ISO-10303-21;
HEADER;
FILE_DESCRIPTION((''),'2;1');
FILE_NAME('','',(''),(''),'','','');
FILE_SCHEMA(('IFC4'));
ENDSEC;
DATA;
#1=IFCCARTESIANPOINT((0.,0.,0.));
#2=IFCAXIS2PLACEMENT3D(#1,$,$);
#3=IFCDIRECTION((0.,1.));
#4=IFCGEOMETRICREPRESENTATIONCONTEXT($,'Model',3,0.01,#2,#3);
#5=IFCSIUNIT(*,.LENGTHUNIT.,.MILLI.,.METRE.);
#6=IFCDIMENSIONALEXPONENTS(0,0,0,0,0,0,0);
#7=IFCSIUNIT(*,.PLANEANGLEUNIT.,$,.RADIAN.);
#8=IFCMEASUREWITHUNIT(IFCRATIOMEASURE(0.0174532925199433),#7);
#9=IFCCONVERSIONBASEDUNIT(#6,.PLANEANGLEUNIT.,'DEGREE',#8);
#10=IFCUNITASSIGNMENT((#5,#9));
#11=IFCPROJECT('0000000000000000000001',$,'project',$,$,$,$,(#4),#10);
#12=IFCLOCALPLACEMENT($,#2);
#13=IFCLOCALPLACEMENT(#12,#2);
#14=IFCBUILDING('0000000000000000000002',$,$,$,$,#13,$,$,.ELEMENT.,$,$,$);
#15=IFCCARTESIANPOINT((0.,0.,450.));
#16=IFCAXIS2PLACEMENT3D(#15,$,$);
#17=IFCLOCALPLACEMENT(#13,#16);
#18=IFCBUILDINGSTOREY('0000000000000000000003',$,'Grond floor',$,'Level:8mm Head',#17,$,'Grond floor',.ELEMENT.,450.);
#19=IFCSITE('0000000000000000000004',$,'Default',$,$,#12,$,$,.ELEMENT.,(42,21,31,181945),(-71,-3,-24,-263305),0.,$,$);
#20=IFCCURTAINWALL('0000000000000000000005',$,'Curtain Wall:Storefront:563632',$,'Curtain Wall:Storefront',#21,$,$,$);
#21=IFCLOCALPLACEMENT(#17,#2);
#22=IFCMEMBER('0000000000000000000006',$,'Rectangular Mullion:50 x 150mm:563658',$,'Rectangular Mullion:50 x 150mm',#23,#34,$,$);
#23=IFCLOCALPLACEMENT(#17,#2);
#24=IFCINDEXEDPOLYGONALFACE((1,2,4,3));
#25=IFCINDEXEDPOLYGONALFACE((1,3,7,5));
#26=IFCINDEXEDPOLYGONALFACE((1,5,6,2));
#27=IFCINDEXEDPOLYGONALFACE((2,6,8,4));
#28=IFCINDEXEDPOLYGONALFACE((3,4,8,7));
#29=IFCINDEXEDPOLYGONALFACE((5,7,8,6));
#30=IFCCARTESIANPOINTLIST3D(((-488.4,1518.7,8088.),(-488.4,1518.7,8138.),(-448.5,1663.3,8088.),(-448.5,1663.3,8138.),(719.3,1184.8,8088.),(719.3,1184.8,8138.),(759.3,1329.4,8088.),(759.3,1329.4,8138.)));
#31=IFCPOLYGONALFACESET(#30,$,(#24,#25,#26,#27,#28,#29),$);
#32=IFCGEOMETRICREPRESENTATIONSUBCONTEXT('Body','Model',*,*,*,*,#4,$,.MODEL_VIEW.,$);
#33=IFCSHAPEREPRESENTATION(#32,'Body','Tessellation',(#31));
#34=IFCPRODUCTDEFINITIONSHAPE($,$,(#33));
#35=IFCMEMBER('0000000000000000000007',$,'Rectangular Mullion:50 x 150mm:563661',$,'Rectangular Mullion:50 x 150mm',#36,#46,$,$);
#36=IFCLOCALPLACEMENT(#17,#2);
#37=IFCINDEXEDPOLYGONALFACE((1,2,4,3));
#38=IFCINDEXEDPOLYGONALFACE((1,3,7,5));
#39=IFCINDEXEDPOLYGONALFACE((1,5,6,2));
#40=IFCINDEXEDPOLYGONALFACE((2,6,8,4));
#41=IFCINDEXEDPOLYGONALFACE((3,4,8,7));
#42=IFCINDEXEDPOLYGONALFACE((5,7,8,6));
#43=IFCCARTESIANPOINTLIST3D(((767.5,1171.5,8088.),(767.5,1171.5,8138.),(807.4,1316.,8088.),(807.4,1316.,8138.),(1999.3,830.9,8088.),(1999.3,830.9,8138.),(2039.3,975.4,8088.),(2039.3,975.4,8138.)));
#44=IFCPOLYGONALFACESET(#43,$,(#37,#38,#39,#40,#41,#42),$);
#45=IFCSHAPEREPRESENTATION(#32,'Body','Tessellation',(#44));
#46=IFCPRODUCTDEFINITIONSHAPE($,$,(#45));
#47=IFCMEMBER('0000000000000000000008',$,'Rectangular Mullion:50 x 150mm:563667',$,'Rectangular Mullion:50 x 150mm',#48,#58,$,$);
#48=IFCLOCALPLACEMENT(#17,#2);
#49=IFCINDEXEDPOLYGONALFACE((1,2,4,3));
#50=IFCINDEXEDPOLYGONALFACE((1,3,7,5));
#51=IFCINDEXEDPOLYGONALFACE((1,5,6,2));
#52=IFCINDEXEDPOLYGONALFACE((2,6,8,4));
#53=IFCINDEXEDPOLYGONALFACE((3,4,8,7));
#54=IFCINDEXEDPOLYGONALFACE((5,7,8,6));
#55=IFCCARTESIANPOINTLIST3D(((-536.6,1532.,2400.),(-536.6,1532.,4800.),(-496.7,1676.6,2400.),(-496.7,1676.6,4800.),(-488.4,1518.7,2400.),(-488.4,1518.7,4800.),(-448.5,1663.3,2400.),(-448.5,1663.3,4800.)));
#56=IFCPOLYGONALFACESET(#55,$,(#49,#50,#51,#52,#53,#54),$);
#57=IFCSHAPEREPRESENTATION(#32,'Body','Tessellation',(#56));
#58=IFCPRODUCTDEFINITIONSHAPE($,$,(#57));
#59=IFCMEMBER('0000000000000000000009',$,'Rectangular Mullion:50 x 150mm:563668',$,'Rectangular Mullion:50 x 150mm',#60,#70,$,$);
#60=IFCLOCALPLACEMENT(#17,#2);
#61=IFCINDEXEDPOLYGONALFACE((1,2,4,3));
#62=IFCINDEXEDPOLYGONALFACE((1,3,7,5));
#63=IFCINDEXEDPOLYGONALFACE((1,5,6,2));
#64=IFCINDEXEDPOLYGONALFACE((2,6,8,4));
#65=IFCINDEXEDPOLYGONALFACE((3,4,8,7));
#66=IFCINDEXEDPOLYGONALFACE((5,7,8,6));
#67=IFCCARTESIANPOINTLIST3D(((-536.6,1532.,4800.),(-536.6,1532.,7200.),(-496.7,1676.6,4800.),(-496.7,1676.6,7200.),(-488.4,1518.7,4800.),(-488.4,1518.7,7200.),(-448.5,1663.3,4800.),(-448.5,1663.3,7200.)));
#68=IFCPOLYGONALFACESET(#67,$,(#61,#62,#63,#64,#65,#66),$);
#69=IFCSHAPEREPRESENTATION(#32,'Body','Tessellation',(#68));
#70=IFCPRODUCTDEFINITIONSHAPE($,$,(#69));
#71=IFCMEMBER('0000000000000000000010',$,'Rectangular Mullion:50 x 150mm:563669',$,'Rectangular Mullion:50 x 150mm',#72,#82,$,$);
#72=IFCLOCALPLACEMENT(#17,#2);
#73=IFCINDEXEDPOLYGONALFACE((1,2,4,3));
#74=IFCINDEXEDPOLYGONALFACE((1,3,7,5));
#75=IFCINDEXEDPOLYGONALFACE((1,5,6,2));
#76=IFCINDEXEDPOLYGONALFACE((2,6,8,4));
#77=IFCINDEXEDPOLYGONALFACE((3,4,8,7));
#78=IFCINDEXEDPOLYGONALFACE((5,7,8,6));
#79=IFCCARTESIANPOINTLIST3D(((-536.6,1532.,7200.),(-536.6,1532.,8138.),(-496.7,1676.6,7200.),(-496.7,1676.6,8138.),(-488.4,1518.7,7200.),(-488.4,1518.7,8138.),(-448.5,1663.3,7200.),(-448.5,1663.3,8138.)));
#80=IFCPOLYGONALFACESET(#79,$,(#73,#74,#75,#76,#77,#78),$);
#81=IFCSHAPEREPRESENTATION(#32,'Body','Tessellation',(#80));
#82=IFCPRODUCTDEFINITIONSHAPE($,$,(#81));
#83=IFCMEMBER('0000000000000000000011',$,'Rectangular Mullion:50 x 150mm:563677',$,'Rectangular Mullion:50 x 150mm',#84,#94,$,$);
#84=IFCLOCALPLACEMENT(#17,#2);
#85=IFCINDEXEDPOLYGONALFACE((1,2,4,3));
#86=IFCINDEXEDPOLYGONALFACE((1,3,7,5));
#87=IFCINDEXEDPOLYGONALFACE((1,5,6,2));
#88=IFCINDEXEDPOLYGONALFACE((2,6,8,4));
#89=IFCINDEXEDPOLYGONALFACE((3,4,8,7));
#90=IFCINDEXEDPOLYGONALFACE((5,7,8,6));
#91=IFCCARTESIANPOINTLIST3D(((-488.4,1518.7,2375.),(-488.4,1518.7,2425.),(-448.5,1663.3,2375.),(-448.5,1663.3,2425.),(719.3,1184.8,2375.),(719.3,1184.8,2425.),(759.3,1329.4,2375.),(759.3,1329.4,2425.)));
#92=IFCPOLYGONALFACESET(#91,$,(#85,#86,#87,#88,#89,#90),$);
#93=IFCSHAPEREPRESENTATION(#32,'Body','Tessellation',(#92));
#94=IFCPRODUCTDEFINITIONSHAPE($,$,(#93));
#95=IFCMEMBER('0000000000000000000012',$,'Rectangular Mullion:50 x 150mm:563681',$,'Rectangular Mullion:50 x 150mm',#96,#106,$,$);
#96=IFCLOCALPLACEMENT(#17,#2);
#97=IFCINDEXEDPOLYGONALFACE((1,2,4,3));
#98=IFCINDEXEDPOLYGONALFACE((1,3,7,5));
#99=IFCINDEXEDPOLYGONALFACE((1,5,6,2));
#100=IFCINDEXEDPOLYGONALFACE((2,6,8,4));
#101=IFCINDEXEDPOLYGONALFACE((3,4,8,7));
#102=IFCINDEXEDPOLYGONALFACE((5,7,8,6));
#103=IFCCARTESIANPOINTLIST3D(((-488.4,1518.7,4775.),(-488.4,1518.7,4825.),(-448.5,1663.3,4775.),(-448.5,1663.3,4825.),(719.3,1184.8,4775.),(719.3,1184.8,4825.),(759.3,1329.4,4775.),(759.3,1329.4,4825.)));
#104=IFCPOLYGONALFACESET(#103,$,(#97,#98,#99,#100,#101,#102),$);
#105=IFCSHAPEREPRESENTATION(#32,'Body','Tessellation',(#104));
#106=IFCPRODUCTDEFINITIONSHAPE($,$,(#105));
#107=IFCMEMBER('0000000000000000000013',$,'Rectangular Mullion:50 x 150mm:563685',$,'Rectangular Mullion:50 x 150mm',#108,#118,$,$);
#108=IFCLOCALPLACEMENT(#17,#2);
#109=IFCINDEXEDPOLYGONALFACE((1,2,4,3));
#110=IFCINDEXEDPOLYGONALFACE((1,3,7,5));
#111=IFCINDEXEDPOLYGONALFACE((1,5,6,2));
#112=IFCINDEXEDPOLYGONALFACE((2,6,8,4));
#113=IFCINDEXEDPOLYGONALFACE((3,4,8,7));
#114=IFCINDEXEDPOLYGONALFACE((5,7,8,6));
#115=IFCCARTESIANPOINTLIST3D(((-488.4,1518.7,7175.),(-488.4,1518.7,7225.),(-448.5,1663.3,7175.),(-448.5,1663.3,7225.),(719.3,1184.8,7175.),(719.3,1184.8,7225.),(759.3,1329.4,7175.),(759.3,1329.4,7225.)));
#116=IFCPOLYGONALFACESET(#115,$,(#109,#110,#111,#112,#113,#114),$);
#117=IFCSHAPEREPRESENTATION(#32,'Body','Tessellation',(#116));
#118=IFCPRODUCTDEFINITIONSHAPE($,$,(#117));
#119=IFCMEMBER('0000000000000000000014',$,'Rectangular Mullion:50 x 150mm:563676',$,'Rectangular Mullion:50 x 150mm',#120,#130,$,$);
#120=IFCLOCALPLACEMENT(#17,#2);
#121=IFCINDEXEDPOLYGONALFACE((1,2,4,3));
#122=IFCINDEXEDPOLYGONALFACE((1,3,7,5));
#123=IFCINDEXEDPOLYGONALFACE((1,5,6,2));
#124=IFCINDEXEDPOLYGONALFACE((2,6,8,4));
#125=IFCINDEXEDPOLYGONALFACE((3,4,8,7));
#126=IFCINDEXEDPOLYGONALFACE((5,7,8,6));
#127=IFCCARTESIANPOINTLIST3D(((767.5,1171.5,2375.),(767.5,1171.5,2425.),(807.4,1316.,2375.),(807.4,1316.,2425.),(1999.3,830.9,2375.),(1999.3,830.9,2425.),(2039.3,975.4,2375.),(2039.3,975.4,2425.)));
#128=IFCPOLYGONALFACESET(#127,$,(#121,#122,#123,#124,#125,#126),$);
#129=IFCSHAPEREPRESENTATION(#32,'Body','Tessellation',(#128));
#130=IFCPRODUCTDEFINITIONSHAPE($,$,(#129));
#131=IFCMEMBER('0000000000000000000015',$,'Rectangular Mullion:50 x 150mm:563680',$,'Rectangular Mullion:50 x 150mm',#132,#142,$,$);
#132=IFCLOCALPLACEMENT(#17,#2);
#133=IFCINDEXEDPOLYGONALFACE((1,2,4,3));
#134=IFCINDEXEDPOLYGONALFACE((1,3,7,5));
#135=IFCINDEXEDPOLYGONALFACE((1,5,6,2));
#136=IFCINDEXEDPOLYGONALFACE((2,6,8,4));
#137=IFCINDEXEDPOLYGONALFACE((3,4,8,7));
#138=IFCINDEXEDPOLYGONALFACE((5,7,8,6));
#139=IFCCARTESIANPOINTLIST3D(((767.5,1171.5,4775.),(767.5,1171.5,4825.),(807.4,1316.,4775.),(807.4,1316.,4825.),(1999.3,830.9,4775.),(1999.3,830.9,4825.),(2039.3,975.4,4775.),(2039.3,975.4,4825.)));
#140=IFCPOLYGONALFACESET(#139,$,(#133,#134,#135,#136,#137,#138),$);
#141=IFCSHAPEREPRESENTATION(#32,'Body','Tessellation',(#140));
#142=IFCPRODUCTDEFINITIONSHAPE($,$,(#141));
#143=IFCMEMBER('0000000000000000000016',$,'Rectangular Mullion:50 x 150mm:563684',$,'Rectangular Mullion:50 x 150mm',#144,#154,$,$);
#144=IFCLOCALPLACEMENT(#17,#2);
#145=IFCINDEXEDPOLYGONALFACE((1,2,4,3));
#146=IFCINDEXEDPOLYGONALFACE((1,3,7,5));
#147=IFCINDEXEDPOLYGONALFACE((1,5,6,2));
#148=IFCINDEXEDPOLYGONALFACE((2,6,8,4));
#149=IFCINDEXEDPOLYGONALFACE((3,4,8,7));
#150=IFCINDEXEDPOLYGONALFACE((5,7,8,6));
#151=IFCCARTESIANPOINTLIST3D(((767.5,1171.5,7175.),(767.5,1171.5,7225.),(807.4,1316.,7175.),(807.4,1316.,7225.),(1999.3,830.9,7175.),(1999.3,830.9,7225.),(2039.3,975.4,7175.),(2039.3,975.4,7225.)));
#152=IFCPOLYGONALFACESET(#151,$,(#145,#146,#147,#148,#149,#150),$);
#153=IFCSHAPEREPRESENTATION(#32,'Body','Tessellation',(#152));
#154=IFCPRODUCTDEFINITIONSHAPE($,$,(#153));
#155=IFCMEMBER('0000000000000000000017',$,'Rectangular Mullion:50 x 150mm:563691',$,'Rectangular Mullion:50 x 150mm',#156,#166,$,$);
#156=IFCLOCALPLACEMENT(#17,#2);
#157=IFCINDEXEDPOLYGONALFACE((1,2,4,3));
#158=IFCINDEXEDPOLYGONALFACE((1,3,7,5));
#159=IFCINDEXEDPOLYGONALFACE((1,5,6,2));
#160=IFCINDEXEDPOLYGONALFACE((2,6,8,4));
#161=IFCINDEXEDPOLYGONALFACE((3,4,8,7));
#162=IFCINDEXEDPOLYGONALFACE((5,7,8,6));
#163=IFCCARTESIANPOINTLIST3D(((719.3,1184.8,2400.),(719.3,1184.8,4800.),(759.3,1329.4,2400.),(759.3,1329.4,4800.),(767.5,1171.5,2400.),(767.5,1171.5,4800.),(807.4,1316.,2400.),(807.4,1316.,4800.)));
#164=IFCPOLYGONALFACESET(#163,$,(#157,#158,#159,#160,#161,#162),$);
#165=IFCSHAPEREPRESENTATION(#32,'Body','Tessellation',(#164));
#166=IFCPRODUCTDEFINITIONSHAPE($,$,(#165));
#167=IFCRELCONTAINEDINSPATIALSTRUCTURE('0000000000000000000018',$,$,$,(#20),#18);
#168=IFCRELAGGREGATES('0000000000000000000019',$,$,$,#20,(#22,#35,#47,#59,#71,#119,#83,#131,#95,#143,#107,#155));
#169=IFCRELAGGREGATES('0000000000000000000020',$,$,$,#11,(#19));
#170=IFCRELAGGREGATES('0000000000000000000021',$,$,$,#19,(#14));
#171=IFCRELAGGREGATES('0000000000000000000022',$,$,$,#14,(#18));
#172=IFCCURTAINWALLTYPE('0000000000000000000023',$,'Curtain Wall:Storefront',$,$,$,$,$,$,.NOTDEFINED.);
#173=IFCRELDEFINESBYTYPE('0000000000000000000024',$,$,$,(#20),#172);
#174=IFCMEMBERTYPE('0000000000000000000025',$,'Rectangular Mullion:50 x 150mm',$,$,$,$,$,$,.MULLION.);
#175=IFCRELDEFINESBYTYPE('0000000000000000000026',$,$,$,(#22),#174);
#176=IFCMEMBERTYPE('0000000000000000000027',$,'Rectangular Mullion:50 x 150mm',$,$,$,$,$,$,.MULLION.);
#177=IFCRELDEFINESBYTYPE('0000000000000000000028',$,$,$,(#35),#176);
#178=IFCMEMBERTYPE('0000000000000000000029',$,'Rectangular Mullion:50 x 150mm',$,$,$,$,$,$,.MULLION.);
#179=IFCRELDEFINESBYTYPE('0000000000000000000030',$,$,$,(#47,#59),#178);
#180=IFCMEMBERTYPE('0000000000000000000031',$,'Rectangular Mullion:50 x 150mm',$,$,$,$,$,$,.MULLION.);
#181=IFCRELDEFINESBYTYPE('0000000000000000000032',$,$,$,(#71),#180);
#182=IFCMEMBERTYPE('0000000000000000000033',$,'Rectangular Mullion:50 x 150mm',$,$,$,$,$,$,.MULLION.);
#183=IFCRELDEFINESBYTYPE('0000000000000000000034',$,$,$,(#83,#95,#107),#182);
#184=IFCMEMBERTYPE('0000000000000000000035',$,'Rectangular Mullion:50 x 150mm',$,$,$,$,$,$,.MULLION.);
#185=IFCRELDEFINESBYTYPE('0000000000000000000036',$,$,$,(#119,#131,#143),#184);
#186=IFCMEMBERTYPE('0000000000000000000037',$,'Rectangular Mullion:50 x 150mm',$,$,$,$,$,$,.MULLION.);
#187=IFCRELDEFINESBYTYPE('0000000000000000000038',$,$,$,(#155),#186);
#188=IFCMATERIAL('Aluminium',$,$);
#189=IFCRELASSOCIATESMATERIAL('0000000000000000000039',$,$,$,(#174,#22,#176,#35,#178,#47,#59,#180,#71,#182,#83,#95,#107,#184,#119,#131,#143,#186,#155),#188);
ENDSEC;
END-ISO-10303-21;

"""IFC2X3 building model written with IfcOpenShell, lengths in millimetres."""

from ifc_helpers import new_model, entity, si_unit, converted_unit, direction, frame, origin, origin_2d_with_axis, place, context, subcontext, project, spatial, rectangle, extrude, source, transform, mapped, material, type_object, type_shapes, element, aggregate, save


model = new_model("IFC2X3")

# Units and contexts
model_context = context("Model", 3, precision=0.01, world=origin(), true_north=direction((0.0, 1.0)))
body_context = subcontext(model_context, "Body", "Model", "MODEL_VIEW")
ifc_project = project(units=[si_unit("LENGTHUNIT", "METRE", prefix="MILLI"), converted_unit("PLANEANGLEUNIT", "DEGREE", entity("IfcRatioMeasure", 0.0174532925199433), si_unit("PLANEANGLEUNIT", "RADIAN"), dimensions=[0, 0, 0, 0, 0, 0, 0])], contexts=[model_context])

# Site, building, storey
site_placement = place(None, origin())
site = spatial("IfcSite", under=ifc_project, at=site_placement, Name="Default", CompositionType="ELEMENT", RefLatitude=(42, 21, 31, 181945), RefLongitude=(-71, -3, -24, -263305), RefElevation=0.0)
building_placement = place(site_placement, origin())
building = spatial("IfcBuilding", under=site, at=building_placement, CompositionType="ELEMENT")
storey_placement = place(building_placement, frame((0.0, 0.0, 450.0)))
storey = spatial("IfcBuildingStorey", under=building, at=storey_placement, Name="Grond floor", ObjectType="Level:8mm Head", LongName="Grond floor", CompositionType="ELEMENT", Elevation=450.0)

# Curtain wall, members
curtain_wall_type = type_object("IfcCurtainWallType", Name="Curtain Wall:Storefront", PredefinedType="NOTDEFINED")
curtain_wall_placement = place(storey_placement, frame((0.0, 0.0, -450.0)))
curtain_wall = element("IfcCurtainWall", 1, at=curtain_wall_placement, inside=storey, type_object=curtain_wall_type, Name="Curtain Wall:Storefront:563632", ObjectType="Curtain Wall:Storefront")
ifc_material_1 = material(Name="Aluminium")
member_type_1 = type_object("IfcMemberType", Name="Rectangular Mullion:50 x 150mm", PredefinedType="MULLION", material=ifc_material_1)
shared_shape_1 = source(origin(), body_context, "Body", "SweptSolid", [
    extrude(rectangle(XDim=150.0, YDim=50.0, at=origin_2d_with_axis()), frame((-25.0, 0.0, -1253.0), z_axis=(0.0, 0.0, 1.0), x_axis=(0.0, -1.0, 0.0)), (0.0, 0.0, 1.0), 1253.0),
])
type_shapes(member_type_1, [shared_shape_1])
member_1_placement = place(storey_placement, frame((-468.4, 1591.0, 8138.0), z_axis=(-0.963836, 0.266496, 0.0), x_axis=(0.0, 0.0, 1.0)))
member_1 = element("IfcMember", 2, at=member_1_placement, type_object=member_type_1, material=ifc_material_1, Name="Rectangular Mullion:50 x 150mm:563658", ObjectType="Rectangular Mullion:50 x 150mm", context=body_context, shape_type="MappedRepresentation", body=[
    mapped(shared_shape_1, transform((0.0, 0.0, 0.0), scale=1.0)),
])
member_type_2 = type_object("IfcMemberType", Name="Rectangular Mullion:50 x 150mm", PredefinedType="MULLION", material=ifc_material_1)
shared_shape_2 = source(origin(), body_context, "Body", "SweptSolid", [
    extrude(rectangle(XDim=150.0, YDim=50.0, at=origin_2d_with_axis()), frame((-25.0, 0.0, -1278.0), z_axis=(0.0, 0.0, 1.0), x_axis=(0.0, -1.0, 0.0)), (0.0, 0.0, 1.0), 1278.0),
])
type_shapes(member_type_2, [shared_shape_2])
member_2_placement = place(storey_placement, frame((787.5, 1243.7, 8138.0), z_axis=(-0.963836, 0.266496, 0.0), x_axis=(0.0, 0.0, 1.0)))
member_2 = element("IfcMember", 3, at=member_2_placement, type_object=member_type_2, material=ifc_material_1, Name="Rectangular Mullion:50 x 150mm:563661", ObjectType="Rectangular Mullion:50 x 150mm", context=body_context, shape_type="MappedRepresentation", body=[
    mapped(shared_shape_2, transform((0.0, 0.0, 0.0), scale=1.0)),
])
member_type_3 = type_object("IfcMemberType", Name="Rectangular Mullion:50 x 150mm", PredefinedType="MULLION", material=ifc_material_1)
shared_shape_3 = source(origin(), body_context, "Body", "SweptSolid", [
    extrude(rectangle(XDim=150.0, YDim=50.0, at=origin_2d_with_axis()), frame((-25.0, 0.0, -2400.0), z_axis=(0.0, 0.0, 1.0), x_axis=(0.0, -1.0, 0.0)), (0.0, 0.0, 1.0), 2400.0),
])
type_shapes(member_type_3, [shared_shape_3])
member_3_placement = place(storey_placement, frame((-516.6, 1604.3, 2400.0), z_axis=(0.0, 0.0, -1.0), x_axis=(-0.963836, 0.266496, 0.0)))
member_3 = element("IfcMember", 4, at=member_3_placement, type_object=member_type_3, material=ifc_material_1, Name="Rectangular Mullion:50 x 150mm:563667", ObjectType="Rectangular Mullion:50 x 150mm", context=body_context, shape_type="MappedRepresentation", body=[
    mapped(shared_shape_3, transform((0.0, 0.0, 0.0), scale=1.0)),
])
member_4_placement = place(storey_placement, frame((-516.6, 1604.3, 4800.0), z_axis=(0.0, 0.0, -1.0), x_axis=(-0.963836, 0.266496, 0.0)))
member_4 = element("IfcMember", 5, at=member_4_placement, type_object=member_type_3, material=ifc_material_1, Name="Rectangular Mullion:50 x 150mm:563668", ObjectType="Rectangular Mullion:50 x 150mm", context=body_context, shape_type="MappedRepresentation", body=[
    mapped(shared_shape_3, transform((0.0, 0.0, 0.0), scale=1.0)),
])
member_type_4 = type_object("IfcMemberType", Name="Rectangular Mullion:50 x 150mm", PredefinedType="MULLION", material=ifc_material_1)
shared_shape_4 = source(origin(), body_context, "Body", "SweptSolid", [
    extrude(rectangle(XDim=150.0, YDim=50.0, at=origin_2d_with_axis()), frame((-25.0, 0.0, -938.0), z_axis=(0.0, 0.0, 1.0), x_axis=(0.0, -1.0, 0.0)), (0.0, 0.0, 1.0), 938.0),
])
type_shapes(member_type_4, [shared_shape_4])
member_5_placement = place(storey_placement, frame((-516.6, 1604.3, 7200.0), z_axis=(0.0, 0.0, -1.0), x_axis=(-0.963836, 0.266496, 0.0)))
member_5 = element("IfcMember", 6, at=member_5_placement, type_object=member_type_4, material=ifc_material_1, Name="Rectangular Mullion:50 x 150mm:563669", ObjectType="Rectangular Mullion:50 x 150mm", context=body_context, shape_type="MappedRepresentation", body=[
    mapped(shared_shape_4, transform((0.0, 0.0, 0.0), scale=1.0)),
])
member_type_5 = type_object("IfcMemberType", Name="Rectangular Mullion:50 x 150mm", PredefinedType="MULLION", material=ifc_material_1)
shared_shape_5 = source(origin(), body_context, "Body", "SweptSolid", [
    extrude(rectangle(XDim=150.0, YDim=50.0, at=origin_2d_with_axis()), frame((0.0, 0.0, -1253.0), z_axis=(0.0, 0.0, 1.0), x_axis=(0.0, -1.0, 0.0)), (0.0, 0.0, 1.0), 1253.0),
])
type_shapes(member_type_5, [shared_shape_5])
member_6_placement = place(storey_placement, frame((-468.4, 1591.0, 2400.0), z_axis=(-0.963836, 0.266496, 0.0), x_axis=(0.0, 0.0, 1.0)))
member_6 = element("IfcMember", 7, at=member_6_placement, type_object=member_type_5, material=ifc_material_1, Name="Rectangular Mullion:50 x 150mm:563677", ObjectType="Rectangular Mullion:50 x 150mm", context=body_context, shape_type="MappedRepresentation", body=[
    mapped(shared_shape_5, transform((0.0, 0.0, 0.0), scale=1.0)),
])
member_7_placement = place(storey_placement, frame((-468.4, 1591.0, 4800.0), z_axis=(-0.963836, 0.266496, 0.0), x_axis=(0.0, 0.0, 1.0)))
member_7 = element("IfcMember", 8, at=member_7_placement, type_object=member_type_5, material=ifc_material_1, Name="Rectangular Mullion:50 x 150mm:563681", ObjectType="Rectangular Mullion:50 x 150mm", context=body_context, shape_type="MappedRepresentation", body=[
    mapped(shared_shape_5, transform((0.0, 0.0, 0.0), scale=1.0)),
])
member_8_placement = place(storey_placement, frame((-468.4, 1591.0, 7200.0), z_axis=(-0.963836, 0.266496, 0.0), x_axis=(0.0, 0.0, 1.0)))
member_8 = element("IfcMember", 9, at=member_8_placement, type_object=member_type_5, material=ifc_material_1, Name="Rectangular Mullion:50 x 150mm:563685", ObjectType="Rectangular Mullion:50 x 150mm", context=body_context, shape_type="MappedRepresentation", body=[
    mapped(shared_shape_5, transform((0.0, 0.0, 0.0), scale=1.0)),
])
member_type_6 = type_object("IfcMemberType", Name="Rectangular Mullion:50 x 150mm", PredefinedType="MULLION", material=ifc_material_1)
shared_shape_6 = source(origin(), body_context, "Body", "SweptSolid", [
    extrude(rectangle(XDim=150.0, YDim=50.0, at=origin_2d_with_axis()), frame((0.0, 0.0, -1278.0), z_axis=(0.0, 0.0, 1.0), x_axis=(0.0, -1.0, 0.0)), (0.0, 0.0, 1.0), 1278.0),
])
type_shapes(member_type_6, [shared_shape_6])
member_9_placement = place(storey_placement, frame((787.5, 1243.7, 2400.0), z_axis=(-0.963836, 0.266496, 0.0), x_axis=(0.0, 0.0, 1.0)))
member_9 = element("IfcMember", 10, at=member_9_placement, type_object=member_type_6, material=ifc_material_1, Name="Rectangular Mullion:50 x 150mm:563676", ObjectType="Rectangular Mullion:50 x 150mm", context=body_context, shape_type="MappedRepresentation", body=[
    mapped(shared_shape_6, transform((0.0, 0.0, 0.0), scale=1.0)),
])
member_10_placement = place(storey_placement, frame((787.5, 1243.7, 4800.0), z_axis=(-0.963836, 0.266496, 0.0), x_axis=(0.0, 0.0, 1.0)))
member_10 = element("IfcMember", 11, at=member_10_placement, type_object=member_type_6, material=ifc_material_1, Name="Rectangular Mullion:50 x 150mm:563680", ObjectType="Rectangular Mullion:50 x 150mm", context=body_context, shape_type="MappedRepresentation", body=[
    mapped(shared_shape_6, transform((0.0, 0.0, 0.0), scale=1.0)),
])
member_11_placement = place(storey_placement, frame((787.5, 1243.7, 7200.0), z_axis=(-0.963836, 0.266496, 0.0), x_axis=(0.0, 0.0, 1.0)))
member_11 = element("IfcMember", 12, at=member_11_placement, type_object=member_type_6, material=ifc_material_1, Name="Rectangular Mullion:50 x 150mm:563684", ObjectType="Rectangular Mullion:50 x 150mm", context=body_context, shape_type="MappedRepresentation", body=[
    mapped(shared_shape_6, transform((0.0, 0.0, 0.0), scale=1.0)),
])
member_type_7 = type_object("IfcMemberType", Name="Rectangular Mullion:50 x 150mm", PredefinedType="MULLION", material=ifc_material_1)
shared_shape_7 = source(origin(), body_context, "Body", "SweptSolid", [
    extrude(rectangle(XDim=150.0, YDim=50.0, at=origin_2d_with_axis()), frame((0.0, 0.0, -2400.0), z_axis=(0.0, 0.0, 1.0), x_axis=(0.0, -1.0, 0.0)), (0.0, 0.0, 1.0), 2400.0),
])
type_shapes(member_type_7, [shared_shape_7])
member_12_placement = place(storey_placement, frame((763.4, 1250.4, 2400.0), z_axis=(0.0, 0.0, -1.0), x_axis=(-0.963836, 0.266496, 0.0)))
member_12 = element("IfcMember", 13, at=member_12_placement, type_object=member_type_7, material=ifc_material_1, Name="Rectangular Mullion:50 x 150mm:563691", ObjectType="Rectangular Mullion:50 x 150mm", context=body_context, shape_type="MappedRepresentation", body=[
    mapped(shared_shape_7, transform((0.0, 0.0, 0.0), scale=1.0)),
])
aggregate(curtain_wall, [member_1, member_2, member_3, member_4, member_5, member_9, member_6, member_10, member_7, member_11, member_8, member_12])

save(model, "model.ifc")
